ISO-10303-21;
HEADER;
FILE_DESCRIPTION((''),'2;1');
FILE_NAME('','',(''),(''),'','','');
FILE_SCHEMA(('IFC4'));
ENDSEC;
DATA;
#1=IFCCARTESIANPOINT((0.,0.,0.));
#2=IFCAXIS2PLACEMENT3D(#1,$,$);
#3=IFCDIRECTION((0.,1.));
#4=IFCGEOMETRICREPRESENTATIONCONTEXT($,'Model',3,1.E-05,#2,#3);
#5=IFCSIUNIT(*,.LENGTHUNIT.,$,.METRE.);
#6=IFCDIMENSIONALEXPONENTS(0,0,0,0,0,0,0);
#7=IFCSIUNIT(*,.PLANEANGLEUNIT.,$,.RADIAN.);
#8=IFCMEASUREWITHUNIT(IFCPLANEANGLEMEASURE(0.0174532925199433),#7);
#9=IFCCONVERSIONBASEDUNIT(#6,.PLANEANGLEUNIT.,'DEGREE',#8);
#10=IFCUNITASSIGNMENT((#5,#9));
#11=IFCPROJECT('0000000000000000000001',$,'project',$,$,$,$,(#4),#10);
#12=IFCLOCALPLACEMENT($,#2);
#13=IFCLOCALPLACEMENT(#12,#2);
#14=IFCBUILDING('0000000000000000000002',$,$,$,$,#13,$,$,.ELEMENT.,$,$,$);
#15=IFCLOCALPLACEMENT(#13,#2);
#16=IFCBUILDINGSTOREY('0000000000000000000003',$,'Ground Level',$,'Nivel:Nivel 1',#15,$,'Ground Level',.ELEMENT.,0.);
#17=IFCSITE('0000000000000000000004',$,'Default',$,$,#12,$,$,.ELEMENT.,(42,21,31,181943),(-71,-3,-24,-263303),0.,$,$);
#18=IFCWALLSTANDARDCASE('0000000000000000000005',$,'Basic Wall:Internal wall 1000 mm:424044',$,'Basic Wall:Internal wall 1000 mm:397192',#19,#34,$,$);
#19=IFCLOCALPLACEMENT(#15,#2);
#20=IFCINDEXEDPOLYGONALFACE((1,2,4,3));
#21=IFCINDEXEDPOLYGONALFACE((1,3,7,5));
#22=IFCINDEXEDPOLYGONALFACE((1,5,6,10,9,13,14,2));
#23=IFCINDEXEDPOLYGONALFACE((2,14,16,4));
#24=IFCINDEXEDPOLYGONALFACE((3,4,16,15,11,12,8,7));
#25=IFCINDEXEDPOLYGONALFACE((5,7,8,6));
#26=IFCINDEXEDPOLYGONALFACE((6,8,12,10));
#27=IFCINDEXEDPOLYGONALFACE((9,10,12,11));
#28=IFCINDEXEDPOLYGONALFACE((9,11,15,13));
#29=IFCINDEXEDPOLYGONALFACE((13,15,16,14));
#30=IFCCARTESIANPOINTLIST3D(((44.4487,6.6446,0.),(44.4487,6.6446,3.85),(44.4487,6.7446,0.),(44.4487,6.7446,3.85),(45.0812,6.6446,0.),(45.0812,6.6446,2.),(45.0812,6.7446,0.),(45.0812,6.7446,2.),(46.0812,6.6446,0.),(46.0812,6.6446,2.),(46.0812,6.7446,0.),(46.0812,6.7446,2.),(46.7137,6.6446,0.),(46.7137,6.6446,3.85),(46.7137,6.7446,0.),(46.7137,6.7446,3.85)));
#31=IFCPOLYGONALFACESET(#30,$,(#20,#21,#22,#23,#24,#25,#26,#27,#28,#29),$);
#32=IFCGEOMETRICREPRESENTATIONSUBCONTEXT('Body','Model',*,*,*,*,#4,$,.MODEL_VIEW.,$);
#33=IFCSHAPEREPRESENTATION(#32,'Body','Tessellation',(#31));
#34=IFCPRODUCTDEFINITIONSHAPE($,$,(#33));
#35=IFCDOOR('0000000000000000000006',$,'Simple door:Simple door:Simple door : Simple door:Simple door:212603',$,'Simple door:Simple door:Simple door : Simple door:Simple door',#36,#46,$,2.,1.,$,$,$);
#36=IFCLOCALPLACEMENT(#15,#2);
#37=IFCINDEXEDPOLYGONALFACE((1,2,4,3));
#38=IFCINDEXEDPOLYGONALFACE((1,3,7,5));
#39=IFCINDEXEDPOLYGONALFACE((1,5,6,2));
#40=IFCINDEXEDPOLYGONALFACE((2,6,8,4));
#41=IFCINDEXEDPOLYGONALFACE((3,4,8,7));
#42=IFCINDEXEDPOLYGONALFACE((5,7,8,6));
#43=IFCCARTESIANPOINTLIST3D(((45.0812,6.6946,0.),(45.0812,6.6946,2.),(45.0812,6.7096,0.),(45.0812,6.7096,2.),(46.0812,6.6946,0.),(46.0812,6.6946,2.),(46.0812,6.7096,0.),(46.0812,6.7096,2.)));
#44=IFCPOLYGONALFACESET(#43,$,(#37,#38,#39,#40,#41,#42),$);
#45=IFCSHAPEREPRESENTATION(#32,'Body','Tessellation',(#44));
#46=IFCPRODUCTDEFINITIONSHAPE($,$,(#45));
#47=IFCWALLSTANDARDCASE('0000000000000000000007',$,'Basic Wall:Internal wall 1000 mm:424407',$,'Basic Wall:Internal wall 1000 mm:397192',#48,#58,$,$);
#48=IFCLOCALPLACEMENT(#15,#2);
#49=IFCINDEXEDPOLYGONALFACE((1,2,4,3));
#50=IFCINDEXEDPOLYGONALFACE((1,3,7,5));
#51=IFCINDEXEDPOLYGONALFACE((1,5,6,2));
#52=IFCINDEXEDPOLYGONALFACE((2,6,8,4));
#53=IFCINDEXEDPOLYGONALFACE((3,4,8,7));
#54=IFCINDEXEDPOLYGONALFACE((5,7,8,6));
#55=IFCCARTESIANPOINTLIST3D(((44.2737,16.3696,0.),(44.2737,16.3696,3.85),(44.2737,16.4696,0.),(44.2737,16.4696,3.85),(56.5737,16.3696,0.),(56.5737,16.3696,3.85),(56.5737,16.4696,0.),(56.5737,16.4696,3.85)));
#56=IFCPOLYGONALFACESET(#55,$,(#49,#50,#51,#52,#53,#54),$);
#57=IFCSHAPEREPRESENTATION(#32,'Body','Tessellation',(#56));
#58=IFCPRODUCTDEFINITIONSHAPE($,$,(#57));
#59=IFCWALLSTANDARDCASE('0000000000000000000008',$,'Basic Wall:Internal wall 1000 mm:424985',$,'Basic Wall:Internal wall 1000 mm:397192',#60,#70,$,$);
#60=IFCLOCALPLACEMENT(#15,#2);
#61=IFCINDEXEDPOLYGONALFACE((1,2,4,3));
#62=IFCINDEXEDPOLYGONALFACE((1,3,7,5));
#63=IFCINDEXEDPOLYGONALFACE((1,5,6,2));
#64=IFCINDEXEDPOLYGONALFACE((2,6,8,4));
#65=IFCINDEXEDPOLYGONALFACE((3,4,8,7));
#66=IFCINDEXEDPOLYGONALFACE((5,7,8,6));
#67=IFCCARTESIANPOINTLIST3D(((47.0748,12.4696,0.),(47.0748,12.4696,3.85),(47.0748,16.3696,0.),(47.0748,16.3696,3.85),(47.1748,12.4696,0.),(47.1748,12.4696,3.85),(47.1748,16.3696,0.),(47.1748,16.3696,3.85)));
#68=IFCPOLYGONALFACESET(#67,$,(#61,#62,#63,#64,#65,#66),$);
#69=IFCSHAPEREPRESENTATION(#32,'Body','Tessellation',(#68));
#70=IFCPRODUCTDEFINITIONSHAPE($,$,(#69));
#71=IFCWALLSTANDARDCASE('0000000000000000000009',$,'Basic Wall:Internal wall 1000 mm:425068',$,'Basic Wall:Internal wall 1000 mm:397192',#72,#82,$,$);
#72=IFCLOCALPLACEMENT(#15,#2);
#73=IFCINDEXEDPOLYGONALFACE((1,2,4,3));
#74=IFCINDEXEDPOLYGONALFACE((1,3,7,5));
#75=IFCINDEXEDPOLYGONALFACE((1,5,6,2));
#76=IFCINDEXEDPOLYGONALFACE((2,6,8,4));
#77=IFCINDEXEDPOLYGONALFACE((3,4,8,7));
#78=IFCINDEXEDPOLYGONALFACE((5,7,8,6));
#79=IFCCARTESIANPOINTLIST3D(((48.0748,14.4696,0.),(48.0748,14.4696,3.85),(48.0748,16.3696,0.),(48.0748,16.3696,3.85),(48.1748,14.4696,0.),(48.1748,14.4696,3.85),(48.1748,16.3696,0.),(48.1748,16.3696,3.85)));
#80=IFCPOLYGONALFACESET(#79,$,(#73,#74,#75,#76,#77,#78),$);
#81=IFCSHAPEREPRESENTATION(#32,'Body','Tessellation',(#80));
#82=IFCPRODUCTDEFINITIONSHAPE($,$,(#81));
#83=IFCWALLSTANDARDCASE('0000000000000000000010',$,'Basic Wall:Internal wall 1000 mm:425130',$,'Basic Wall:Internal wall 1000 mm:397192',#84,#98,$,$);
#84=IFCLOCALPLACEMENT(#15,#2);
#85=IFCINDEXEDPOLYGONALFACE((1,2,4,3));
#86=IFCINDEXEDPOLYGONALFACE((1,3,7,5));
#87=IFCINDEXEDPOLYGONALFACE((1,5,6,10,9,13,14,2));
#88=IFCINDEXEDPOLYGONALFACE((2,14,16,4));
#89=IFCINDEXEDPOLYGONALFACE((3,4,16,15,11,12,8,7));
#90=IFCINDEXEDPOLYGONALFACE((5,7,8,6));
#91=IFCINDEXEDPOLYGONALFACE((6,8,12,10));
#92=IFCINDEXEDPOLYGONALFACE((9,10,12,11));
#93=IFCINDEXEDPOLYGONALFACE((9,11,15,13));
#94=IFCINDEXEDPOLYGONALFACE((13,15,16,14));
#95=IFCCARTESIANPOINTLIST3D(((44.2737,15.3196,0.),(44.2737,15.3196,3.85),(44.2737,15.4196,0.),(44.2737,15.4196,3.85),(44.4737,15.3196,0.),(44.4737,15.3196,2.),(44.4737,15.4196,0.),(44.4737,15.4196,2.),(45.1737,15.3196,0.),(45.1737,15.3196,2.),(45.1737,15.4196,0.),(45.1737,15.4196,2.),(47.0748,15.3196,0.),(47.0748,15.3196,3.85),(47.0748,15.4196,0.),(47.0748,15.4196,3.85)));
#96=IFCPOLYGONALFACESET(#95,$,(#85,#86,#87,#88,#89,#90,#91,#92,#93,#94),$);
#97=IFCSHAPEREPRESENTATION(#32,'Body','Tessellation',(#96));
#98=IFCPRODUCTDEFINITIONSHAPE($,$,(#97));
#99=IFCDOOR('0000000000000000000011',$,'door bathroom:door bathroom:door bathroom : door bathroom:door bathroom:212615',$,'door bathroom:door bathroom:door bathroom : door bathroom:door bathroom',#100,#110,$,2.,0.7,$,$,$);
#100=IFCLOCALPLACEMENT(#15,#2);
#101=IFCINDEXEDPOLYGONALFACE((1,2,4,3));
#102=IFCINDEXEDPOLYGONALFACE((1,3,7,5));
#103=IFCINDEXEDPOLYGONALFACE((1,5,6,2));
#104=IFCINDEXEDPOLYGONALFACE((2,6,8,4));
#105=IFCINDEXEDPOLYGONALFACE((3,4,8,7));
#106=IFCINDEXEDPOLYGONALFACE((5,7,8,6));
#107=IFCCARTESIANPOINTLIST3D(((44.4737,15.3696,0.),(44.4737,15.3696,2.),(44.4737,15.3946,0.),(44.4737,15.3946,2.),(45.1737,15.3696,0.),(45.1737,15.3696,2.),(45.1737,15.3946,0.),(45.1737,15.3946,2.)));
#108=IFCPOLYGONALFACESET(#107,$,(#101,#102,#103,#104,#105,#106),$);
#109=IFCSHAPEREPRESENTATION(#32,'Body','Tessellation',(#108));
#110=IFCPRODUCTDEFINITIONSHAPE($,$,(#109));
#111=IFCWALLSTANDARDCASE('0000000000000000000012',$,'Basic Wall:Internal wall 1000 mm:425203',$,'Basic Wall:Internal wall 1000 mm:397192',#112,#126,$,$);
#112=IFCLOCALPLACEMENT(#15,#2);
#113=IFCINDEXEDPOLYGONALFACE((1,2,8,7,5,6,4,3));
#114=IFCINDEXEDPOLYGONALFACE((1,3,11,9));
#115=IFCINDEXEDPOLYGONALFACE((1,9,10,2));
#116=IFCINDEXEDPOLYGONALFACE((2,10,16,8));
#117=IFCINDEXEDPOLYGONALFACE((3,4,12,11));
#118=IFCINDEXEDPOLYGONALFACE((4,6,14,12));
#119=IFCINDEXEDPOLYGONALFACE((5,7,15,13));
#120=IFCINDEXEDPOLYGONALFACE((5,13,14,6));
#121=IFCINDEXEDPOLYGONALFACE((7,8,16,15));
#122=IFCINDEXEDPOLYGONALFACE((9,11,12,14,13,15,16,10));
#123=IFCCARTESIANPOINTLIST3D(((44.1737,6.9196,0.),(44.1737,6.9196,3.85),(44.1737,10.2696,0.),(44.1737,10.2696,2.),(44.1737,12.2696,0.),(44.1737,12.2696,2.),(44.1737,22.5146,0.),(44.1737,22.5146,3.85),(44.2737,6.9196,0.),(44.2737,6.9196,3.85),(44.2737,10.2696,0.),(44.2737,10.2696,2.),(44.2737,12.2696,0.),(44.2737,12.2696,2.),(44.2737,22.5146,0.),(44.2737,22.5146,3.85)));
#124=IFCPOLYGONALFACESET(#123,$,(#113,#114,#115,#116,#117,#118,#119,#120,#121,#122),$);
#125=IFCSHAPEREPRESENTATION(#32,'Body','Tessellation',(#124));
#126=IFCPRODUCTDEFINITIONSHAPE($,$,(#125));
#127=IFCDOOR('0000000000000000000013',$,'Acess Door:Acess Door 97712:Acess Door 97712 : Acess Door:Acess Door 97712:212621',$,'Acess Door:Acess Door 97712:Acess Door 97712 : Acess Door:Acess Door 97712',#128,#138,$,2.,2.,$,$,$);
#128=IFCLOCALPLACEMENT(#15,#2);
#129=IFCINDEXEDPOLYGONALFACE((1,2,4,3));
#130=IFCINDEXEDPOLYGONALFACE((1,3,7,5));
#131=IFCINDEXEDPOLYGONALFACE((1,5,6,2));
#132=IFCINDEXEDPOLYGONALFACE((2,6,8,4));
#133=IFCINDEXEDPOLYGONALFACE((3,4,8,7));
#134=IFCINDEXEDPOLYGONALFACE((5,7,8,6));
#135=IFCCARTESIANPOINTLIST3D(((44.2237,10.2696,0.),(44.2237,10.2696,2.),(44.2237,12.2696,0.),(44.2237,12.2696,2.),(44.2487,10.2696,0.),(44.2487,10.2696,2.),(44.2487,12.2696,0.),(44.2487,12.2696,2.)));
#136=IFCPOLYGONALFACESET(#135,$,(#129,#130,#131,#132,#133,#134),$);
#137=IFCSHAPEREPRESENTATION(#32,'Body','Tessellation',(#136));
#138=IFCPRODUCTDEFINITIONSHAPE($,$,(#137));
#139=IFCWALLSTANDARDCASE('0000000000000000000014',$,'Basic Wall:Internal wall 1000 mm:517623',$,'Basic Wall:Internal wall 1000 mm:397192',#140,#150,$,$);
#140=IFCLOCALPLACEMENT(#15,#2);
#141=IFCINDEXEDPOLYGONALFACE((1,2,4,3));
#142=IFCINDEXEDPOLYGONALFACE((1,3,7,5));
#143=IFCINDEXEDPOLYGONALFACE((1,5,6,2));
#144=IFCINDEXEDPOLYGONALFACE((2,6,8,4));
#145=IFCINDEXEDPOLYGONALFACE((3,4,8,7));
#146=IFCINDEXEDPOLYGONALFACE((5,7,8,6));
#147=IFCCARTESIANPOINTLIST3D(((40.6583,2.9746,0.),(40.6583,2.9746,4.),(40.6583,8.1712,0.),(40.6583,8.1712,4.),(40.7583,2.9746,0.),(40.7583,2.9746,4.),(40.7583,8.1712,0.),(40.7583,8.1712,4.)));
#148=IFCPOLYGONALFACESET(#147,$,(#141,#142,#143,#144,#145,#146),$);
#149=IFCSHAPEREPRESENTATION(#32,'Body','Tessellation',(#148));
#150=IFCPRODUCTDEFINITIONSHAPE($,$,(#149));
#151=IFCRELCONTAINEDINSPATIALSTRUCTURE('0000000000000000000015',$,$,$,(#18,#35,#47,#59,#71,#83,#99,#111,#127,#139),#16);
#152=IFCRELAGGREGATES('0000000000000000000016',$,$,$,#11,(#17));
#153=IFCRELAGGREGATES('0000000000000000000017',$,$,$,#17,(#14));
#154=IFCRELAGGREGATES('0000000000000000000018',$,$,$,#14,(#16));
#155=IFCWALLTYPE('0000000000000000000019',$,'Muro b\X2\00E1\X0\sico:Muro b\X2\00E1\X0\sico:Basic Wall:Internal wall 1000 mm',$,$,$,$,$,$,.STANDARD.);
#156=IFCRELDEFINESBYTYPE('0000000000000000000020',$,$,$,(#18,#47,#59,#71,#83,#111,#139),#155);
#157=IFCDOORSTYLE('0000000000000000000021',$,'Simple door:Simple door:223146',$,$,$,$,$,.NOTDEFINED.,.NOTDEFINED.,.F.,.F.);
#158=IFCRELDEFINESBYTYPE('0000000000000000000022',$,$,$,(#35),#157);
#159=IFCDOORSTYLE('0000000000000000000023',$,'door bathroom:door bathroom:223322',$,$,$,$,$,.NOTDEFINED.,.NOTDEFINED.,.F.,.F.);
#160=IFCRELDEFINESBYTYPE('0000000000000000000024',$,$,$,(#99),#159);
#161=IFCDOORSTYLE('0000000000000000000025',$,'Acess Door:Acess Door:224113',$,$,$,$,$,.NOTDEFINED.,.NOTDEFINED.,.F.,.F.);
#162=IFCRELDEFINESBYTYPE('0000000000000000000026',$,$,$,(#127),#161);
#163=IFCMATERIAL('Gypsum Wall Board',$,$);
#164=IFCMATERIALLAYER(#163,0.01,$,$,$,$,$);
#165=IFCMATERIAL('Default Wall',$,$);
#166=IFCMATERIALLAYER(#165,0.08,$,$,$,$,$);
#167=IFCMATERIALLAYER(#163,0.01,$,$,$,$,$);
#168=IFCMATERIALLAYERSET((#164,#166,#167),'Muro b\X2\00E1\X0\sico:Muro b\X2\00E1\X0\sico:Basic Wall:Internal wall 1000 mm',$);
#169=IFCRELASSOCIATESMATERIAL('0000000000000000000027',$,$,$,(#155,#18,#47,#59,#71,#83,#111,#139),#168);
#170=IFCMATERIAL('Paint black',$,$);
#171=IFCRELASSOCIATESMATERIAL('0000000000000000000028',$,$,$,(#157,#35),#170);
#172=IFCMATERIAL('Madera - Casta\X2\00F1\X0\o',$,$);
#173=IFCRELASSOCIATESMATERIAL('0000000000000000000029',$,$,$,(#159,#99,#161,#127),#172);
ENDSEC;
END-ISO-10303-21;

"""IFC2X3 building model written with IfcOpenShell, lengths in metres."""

from ifc_helpers import new_model, entity, si_unit, converted_unit, direction, frame, frame_2d, origin, origin_2d_with_axis, place, context, subcontext, project, spatial, rectangle, extrude, source, transform, mapped, material, layer, layer_set, layer_usage, type_object, type_shapes, element, fill, save


model = new_model("IFC2X3")

# Units and contexts
model_context = context("Model", 3, precision=1e-05, world=origin(), true_north=direction((0.0, 1.0)))
body_context = subcontext(model_context, "Body", "Model", "MODEL_VIEW")
ifc_project = project(units=[si_unit("LENGTHUNIT", "METRE"), converted_unit("PLANEANGLEUNIT", "DEGREE", entity("IfcPlaneAngleMeasure", 0.0174532925199433), si_unit("PLANEANGLEUNIT", "RADIAN"), dimensions=[0, 0, 0, 0, 0, 0, 0])], contexts=[model_context])

# Site, building, storey
site_placement = place(None, origin())
site = spatial("IfcSite", under=ifc_project, at=site_placement, Name="Default", CompositionType="ELEMENT", RefLatitude=(42, 21, 31, 181943), RefLongitude=(-71, -3, -24, -263303), RefElevation=0.0)
building_placement = place(site_placement, origin())
building = spatial("IfcBuilding", under=site, at=building_placement, CompositionType="ELEMENT")
storey_placement = place(building_placement, origin())
storey = spatial("IfcBuildingStorey", under=building, at=storey_placement, Name="Ground Level", ObjectType="Nivel:Nivel 1", LongName="Ground Level", CompositionType="ELEMENT", Elevation=0.0)

# Wall, opening, door
ifc_material_1 = material(Name="Gypsum Wall Board")
ifc_layer_1 = layer(ifc_material_1, 0.01)
ifc_material_2 = material(Name="Default Wall")
ifc_layer_2 = layer(ifc_material_2, 0.08)
ifc_layer_3 = layer(ifc_material_1, 0.01)
ifc_layer_set_1 = layer_set([ifc_layer_1, ifc_layer_2, ifc_layer_3], Name="Muro básico:Muro básico:Basic Wall:Internal wall 1000 mm")
ifc_layer_usage_1 = layer_usage(ifc_layer_set_1, "AXIS2", "NEGATIVE", 0.05)
wall_type_1 = type_object("IfcWallType", Name="Muro básico:Muro básico:Basic Wall:Internal wall 1000 mm", PredefinedType="STANDARD", material=ifc_layer_set_1)
wall_1_placement = place(storey_placement, frame((46.7137, 6.6946, 0.0), z_axis=(0.0, 0.0, 1.0), x_axis=(-1.0, 0.0, 0.0)))
wall_1 = element("IfcWallStandardCase", 1, at=wall_1_placement, inside=storey, type_object=wall_type_1, material=ifc_layer_usage_1, Name="Basic Wall:Internal wall 1000 mm:424044", ObjectType="Basic Wall:Internal wall 1000 mm:397192", context=body_context, shape_type="SweptSolid", body=[
    extrude(rectangle(XDim=2.265, YDim=0.1, at=frame_2d((1.1325, 0.0), x_axis=(1.0, 0.0))), origin(), (0.0, 0.0, 1.0), 3.85),
])
opening_1_placement = place(wall_1_placement, frame((46.7137, 6.6946, 0.0), z_axis=(0.0, 0.0, 1.0), x_axis=(-1.0, 0.0, 0.0)))
opening_1 = element("IfcOpeningElement", 2, at=opening_1_placement, cuts=wall_1, ObjectType="Opening", context=body_context, shape_type="SweptSolid", body=[
    extrude(rectangle(XDim=2.0, YDim=1.0, at=frame_2d((0.0, 0.0), x_axis=(0.0, 1.0))), frame((45.5812, 6.7467, 1.0), z_axis=(0.0, -1.0, 0.0), x_axis=(1.0, 0.0, 0.0)), (0.0, 0.0, 1.0), 0.104),
])
ifc_material_3 = material(Name="Paint black")
door_style_1 = type_object("IfcDoorStyle", Name="Simple door:Simple door:223146", ConstructionType="NOTDEFINED", OperationType="NOTDEFINED", ParameterTakesPrecedence=False, Sizeable=False, material=ifc_material_3)
shared_shape_1 = source(origin(), body_context, "Body", "SweptSolid", [
    extrude(rectangle(XDim=1.0, YDim=0.015, at=origin_2d_with_axis()), frame((0.5, -0.0595, 0.0)), (0.0, 0.0, 1.0), 2.0),
])
type_shapes(door_style_1, [shared_shape_1])
door_1_placement = place(opening_1_placement, frame((46.0812, 6.6426, 0.0), z_axis=(0.0, 0.0, 1.0), x_axis=(-1.0, 0.0, 0.0)))
door_1 = element("IfcDoor", 3, at=door_1_placement, inside=storey, type_object=door_style_1, material=ifc_material_3, Name="Simple door:Simple door:Simple door : Simple door:Simple door:212603", ObjectType="Simple door:Simple door:Simple door : Simple door:Simple door", OverallHeight=2.0, OverallWidth=1.0, context=body_context, shape_type="MappedRepresentation", body=[
    mapped(shared_shape_1, transform((0.0, 0.0, 0.0), scale=1.0)),
])
fill(opening_1, door_1)

# Walls
ifc_layer_usage_2 = layer_usage(ifc_layer_set_1, "AXIS2", "NEGATIVE", 0.05)
wall_2_placement = place(storey_placement, frame((44.2737, 16.4196, 0.0)))
element("IfcWallStandardCase", 4, at=wall_2_placement, inside=storey, type_object=wall_type_1, material=ifc_layer_usage_2, Name="Basic Wall:Internal wall 1000 mm:424407", ObjectType="Basic Wall:Internal wall 1000 mm:397192", context=body_context, shape_type="SweptSolid", body=[
    extrude(rectangle(XDim=12.3, YDim=0.1, at=frame_2d((6.15, 0.0), x_axis=(-1.0, 0.0))), origin(), (0.0, 0.0, 1.0), 3.85),
])
ifc_layer_usage_3 = layer_usage(ifc_layer_set_1, "AXIS2", "NEGATIVE", 0.05)
wall_3_placement = place(storey_placement, frame((47.1248, 16.3696, 0.0), z_axis=(0.0, 0.0, 1.0), x_axis=(0.0, -1.0, 0.0)))
element("IfcWallStandardCase", 5, at=wall_3_placement, inside=storey, type_object=wall_type_1, material=ifc_layer_usage_3, Name="Basic Wall:Internal wall 1000 mm:424985", ObjectType="Basic Wall:Internal wall 1000 mm:397192", context=body_context, shape_type="SweptSolid", body=[
    extrude(rectangle(XDim=3.9, YDim=0.1, at=frame_2d((1.95, 0.0), x_axis=(-1.0, 0.0))), origin(), (0.0, 0.0, 1.0), 3.85),
])
ifc_layer_usage_4 = layer_usage(ifc_layer_set_1, "AXIS2", "NEGATIVE", 0.05)
wall_4_placement = place(storey_placement, frame((48.1248, 14.4696, 0.0), z_axis=(0.0, 0.0, 1.0), x_axis=(0.0, 1.0, 0.0)))
element("IfcWallStandardCase", 6, at=wall_4_placement, inside=storey, type_object=wall_type_1, material=ifc_layer_usage_4, Name="Basic Wall:Internal wall 1000 mm:425068", ObjectType="Basic Wall:Internal wall 1000 mm:397192", context=body_context, shape_type="SweptSolid", body=[
    extrude(rectangle(XDim=1.9, YDim=0.1, at=frame_2d((0.95, 0.0), x_axis=(-1.0, 0.0))), origin(), (0.0, 0.0, 1.0), 3.85),
])

# Walls, openings, doors
ifc_layer_usage_5 = layer_usage(ifc_layer_set_1, "AXIS2", "NEGATIVE", 0.05)
wall_5_placement = place(storey_placement, frame((44.2737, 15.3696, 0.0)))
wall_5 = element("IfcWallStandardCase", 7, at=wall_5_placement, inside=storey, type_object=wall_type_1, material=ifc_layer_usage_5, Name="Basic Wall:Internal wall 1000 mm:425130", ObjectType="Basic Wall:Internal wall 1000 mm:397192", context=body_context, shape_type="SweptSolid", body=[
    extrude(rectangle(XDim=2.8011, YDim=0.1, at=frame_2d((1.4006, 0.0), x_axis=(1.0, 0.0))), origin(), (0.0, 0.0, 1.0), 3.85),
])
opening_2_placement = place(wall_5_placement, frame((-44.2737, -15.3696, 0.0)))
opening_2 = element("IfcOpeningElement", 8, at=opening_2_placement, cuts=wall_5, ObjectType="Opening", context=body_context, shape_type="SweptSolid", body=[
    extrude(rectangle(XDim=2.0, YDim=0.7, at=frame_2d((0.0, 0.0), x_axis=(0.0, 1.0))), frame((44.8237, 15.3176, 1.0), z_axis=(0.0, 1.0, 0.0), x_axis=(-1.0, 0.0, 0.0)), (0.0, 0.0, 1.0), 0.104),
])
ifc_material_4 = material(Name="Madera - Castaño")
door_style_2 = type_object("IfcDoorStyle", Name="door bathroom:door bathroom:223322", ConstructionType="NOTDEFINED", OperationType="NOTDEFINED", ParameterTakesPrecedence=False, Sizeable=False, material=ifc_material_4)
shared_shape_2 = source(origin(), body_context, "Body", "SweptSolid", [
    extrude(rectangle(XDim=0.7, YDim=0.025, at=origin_2d_with_axis()), frame((0.35, 0.0395, 0.0)), (0.0, 0.0, 1.0), 2.0),
])
type_shapes(door_style_2, [shared_shape_2])
door_2_placement = place(opening_2_placement, frame((45.1737, 15.4217, 0.0), z_axis=(0.0, 0.0, 1.0), x_axis=(-1.0, 0.0, 0.0)))
door_2 = element("IfcDoor", 9, at=door_2_placement, inside=storey, type_object=door_style_2, material=ifc_material_4, Name="door bathroom:door bathroom:door bathroom : door bathroom:door bathroom:212615", ObjectType="door bathroom:door bathroom:door bathroom : door bathroom:door bathroom", OverallHeight=2.0, OverallWidth=0.7, context=body_context, shape_type="MappedRepresentation", body=[
    mapped(shared_shape_2, transform((0.0, 0.0, 0.0), scale=1.0)),
])
fill(opening_2, door_2)
ifc_layer_usage_6 = layer_usage(ifc_layer_set_1, "AXIS2", "NEGATIVE", 0.05)
wall_6_placement = place(storey_placement, frame((44.2237, 6.9196, 0.0), z_axis=(0.0, 0.0, 1.0), x_axis=(0.0, 1.0, 0.0)))
wall_6 = element("IfcWallStandardCase", 10, at=wall_6_placement, inside=storey, type_object=wall_type_1, material=ifc_layer_usage_6, Name="Basic Wall:Internal wall 1000 mm:425203", ObjectType="Basic Wall:Internal wall 1000 mm:397192", context=body_context, shape_type="SweptSolid", body=[
    extrude(rectangle(XDim=15.595, YDim=0.1, at=frame_2d((7.7975, 0.0), x_axis=(1.0, 0.0))), origin(), (0.0, 0.0, 1.0), 3.85),
])
opening_3_placement = place(wall_6_placement, frame((-6.9196, 44.2237, 0.0), z_axis=(0.0, 0.0, 1.0), x_axis=(0.0, -1.0, 0.0)))
opening_3 = element("IfcOpeningElement", 11, at=opening_3_placement, cuts=wall_6, ObjectType="Opening", context=body_context, shape_type="SweptSolid", body=[
    extrude(rectangle(XDim=2.0, YDim=2.0, at=frame_2d((0.0, 0.0), x_axis=(0.0, 1.0))), frame((44.2757, 11.2696, 1.0), z_axis=(-1.0, 0.0, 0.0), x_axis=(0.0, -1.0, 0.0)), (0.0, 0.0, 1.0), 0.104),
])
door_style_3 = type_object("IfcDoorStyle", Name="Acess Door:Acess Door:224113", ConstructionType="NOTDEFINED", OperationType="NOTDEFINED", ParameterTakesPrecedence=False, Sizeable=False, material=ifc_material_4)
shared_shape_3 = source(origin(), body_context, "Body", "SweptSolid", [
    extrude(rectangle(XDim=2.0, YDim=0.025, at=origin_2d_with_axis()), frame((1.0, -0.0645, 0.0)), (0.0, 0.0, 1.0), 2.0),
])
type_shapes(door_style_3, [shared_shape_3])
door_3_placement = place(opening_3_placement, frame((44.1717, 10.2696, 0.0), z_axis=(0.0, 0.0, 1.0), x_axis=(0.0, 1.0, 0.0)))
door_3 = element("IfcDoor", 12, at=door_3_placement, inside=storey, type_object=door_style_3, material=ifc_material_4, Name="Acess Door:Acess Door 97712:Acess Door 97712 : Acess Door:Acess Door 97712:212621", ObjectType="Acess Door:Acess Door 97712:Acess Door 97712 : Acess Door:Acess Door 97712", OverallHeight=2.0, OverallWidth=2.0, context=body_context, shape_type="MappedRepresentation", body=[
    mapped(shared_shape_3, transform((0.0, 0.0, 0.0), scale=1.0)),
])
fill(opening_3, door_3)

# Wall
ifc_layer_usage_7 = layer_usage(ifc_layer_set_1, "AXIS2", "NEGATIVE", 0.05)
wall_7_placement = place(storey_placement, frame((40.7083, 8.1712, 0.0), z_axis=(0.0, 0.0, 1.0), x_axis=(0.0, -1.0, 0.0)))
element("IfcWallStandardCase", 13, at=wall_7_placement, inside=storey, type_object=wall_type_1, material=ifc_layer_usage_7, Name="Basic Wall:Internal wall 1000 mm:517623", ObjectType="Basic Wall:Internal wall 1000 mm:397192", context=body_context, shape_type="SweptSolid", body=[
    extrude(rectangle(XDim=5.1966, YDim=0.1, at=frame_2d((2.5983, 0.0), x_axis=(-1.0, 0.0))), origin(), (0.0, 0.0, 1.0), 4.0),
])

save(model, "model.ifc")
